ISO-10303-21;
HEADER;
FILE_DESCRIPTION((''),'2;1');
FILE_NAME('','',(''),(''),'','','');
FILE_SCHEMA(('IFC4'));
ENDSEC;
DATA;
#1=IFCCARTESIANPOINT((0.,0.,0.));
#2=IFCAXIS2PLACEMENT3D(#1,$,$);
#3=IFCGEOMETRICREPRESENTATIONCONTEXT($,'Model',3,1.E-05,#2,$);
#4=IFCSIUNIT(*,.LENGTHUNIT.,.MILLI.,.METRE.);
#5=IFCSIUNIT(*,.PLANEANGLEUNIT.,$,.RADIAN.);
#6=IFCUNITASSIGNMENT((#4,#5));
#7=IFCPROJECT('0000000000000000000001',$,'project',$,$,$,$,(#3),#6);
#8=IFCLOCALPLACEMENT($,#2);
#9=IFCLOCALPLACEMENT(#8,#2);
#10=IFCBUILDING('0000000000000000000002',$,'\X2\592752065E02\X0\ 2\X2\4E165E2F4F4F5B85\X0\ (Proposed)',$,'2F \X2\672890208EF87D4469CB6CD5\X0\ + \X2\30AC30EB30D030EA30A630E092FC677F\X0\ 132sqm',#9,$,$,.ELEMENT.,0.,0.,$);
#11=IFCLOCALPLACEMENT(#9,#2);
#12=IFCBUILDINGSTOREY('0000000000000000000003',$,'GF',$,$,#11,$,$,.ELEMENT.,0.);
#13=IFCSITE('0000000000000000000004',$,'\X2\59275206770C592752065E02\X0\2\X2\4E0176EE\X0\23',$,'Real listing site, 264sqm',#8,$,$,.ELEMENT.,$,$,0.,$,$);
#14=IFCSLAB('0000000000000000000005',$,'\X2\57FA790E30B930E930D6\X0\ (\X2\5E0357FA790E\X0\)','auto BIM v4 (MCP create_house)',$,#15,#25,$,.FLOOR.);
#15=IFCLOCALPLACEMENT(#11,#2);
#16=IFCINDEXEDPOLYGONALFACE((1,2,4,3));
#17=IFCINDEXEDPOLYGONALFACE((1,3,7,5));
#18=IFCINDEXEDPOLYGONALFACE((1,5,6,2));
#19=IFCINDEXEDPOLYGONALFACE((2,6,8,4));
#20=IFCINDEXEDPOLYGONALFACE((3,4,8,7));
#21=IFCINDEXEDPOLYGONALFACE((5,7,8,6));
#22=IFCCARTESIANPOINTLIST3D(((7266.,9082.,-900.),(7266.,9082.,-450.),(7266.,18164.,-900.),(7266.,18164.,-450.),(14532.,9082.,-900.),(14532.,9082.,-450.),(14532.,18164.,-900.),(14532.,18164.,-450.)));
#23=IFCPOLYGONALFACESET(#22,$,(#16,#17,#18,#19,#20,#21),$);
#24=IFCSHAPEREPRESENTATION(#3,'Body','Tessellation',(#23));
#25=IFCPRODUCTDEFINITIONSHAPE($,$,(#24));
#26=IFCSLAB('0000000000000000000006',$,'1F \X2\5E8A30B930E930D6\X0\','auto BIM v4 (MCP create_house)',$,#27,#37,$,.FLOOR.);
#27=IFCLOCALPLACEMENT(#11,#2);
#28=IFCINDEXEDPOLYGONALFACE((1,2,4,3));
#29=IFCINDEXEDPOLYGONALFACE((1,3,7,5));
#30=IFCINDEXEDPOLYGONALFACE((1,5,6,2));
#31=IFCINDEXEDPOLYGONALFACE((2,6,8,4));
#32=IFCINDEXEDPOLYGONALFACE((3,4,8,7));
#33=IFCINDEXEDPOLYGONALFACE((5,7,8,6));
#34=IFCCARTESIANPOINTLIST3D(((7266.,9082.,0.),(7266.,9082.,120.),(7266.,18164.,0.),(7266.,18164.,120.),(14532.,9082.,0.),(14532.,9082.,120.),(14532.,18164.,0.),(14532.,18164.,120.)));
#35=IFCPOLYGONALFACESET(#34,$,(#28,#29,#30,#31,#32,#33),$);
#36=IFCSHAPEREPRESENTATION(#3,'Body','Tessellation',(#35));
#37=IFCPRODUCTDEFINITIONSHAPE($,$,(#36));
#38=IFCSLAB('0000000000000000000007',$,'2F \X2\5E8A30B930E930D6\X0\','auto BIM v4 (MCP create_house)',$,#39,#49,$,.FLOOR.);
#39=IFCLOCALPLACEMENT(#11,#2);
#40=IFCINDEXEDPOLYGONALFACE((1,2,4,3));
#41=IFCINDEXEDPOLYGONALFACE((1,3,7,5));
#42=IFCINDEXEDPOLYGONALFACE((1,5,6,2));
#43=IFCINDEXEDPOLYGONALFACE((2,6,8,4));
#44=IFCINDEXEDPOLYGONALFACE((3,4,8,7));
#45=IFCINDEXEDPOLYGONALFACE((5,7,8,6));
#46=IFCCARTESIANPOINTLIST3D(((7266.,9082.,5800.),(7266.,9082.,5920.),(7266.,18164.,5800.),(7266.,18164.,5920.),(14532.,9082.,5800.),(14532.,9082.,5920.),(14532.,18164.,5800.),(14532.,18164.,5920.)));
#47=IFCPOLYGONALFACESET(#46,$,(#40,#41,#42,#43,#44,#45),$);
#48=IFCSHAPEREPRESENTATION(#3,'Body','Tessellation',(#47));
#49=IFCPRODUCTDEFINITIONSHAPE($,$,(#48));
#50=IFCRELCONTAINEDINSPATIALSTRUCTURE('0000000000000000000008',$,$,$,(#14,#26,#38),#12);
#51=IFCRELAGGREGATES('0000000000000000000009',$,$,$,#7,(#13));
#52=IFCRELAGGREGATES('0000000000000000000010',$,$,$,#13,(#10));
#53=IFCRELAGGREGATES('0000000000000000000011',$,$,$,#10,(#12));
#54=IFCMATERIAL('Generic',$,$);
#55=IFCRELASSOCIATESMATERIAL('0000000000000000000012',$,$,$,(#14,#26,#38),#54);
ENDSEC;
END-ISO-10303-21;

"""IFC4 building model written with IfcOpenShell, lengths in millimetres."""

from ifc_helpers import new_model, si_unit, frame, frame_2d, origin, place, context, project, spatial, rectangle, extrude, material, element, save


model = new_model("IFC4")

# Units and contexts
model_context = context("Model", 3, precision=1e-05, world=origin())
ifc_project = project(units=[si_unit("LENGTHUNIT", "METRE", prefix="MILLI"), si_unit("PLANEANGLEUNIT", "RADIAN")], contexts=[model_context])

# Site, building, storey
site_placement = place(None, origin())
site = spatial("IfcSite", under=ifc_project, at=site_placement, Name="大分県大分市2丁目23", ObjectType="Real listing site, 264sqm", CompositionType="ELEMENT", RefElevation=0.0)
building_placement = place(site_placement, origin())
building = spatial("IfcBuilding", under=site, at=building_placement, Name="大分市 2世帯住宅 (Proposed)", ObjectType="2F 木造軸組構法 + ガルバリウム鋼板 132sqm", CompositionType="ELEMENT", ElevationOfRefHeight=0.0, ElevationOfTerrain=0.0)
storey_placement = place(building_placement, origin())
storey = spatial("IfcBuildingStorey", under=building, at=storey_placement, Name="GF", CompositionType="ELEMENT", Elevation=0.0)

# Slabs
ifc_material = material(Name="Generic")
slab_1_placement = place(storey_placement, frame((3633.0, 4541.0, -450.0)))
element("IfcSlab", 1, at=slab_1_placement, inside=storey, material=ifc_material, Name="基礎スラブ (布基礎)", Description="auto BIM v4 (MCP create_house)", PredefinedType="FLOOR", context=model_context, shape_type="SweptSolid", body=[
    extrude(rectangle(XDim=7266.0, YDim=9082.0, at=frame_2d((3633.0, 4541.0))), frame((3633.0, 4541.0, -450.0)), (0.0, 0.0, 1.0), 450.0),
])
slab_2_placement = place(storey_placement, frame((3633.0, 4541.0, 0.0)))
element("IfcSlab", 2, at=slab_2_placement, inside=storey, material=ifc_material, Name="1F 床スラブ", Description="auto BIM v4 (MCP create_house)", PredefinedType="FLOOR", context=model_context, shape_type="SweptSolid", body=[
    extrude(rectangle(XDim=7266.0, YDim=9082.0, at=frame_2d((3633.0, 4541.0))), frame((3633.0, 4541.0, 0.0)), (0.0, 0.0, 1.0), 120.0),
])
slab_3_placement = place(storey_placement, frame((3633.0, 4541.0, 2900.0)))
element("IfcSlab", 3, at=slab_3_placement, inside=storey, material=ifc_material, Name="2F 床スラブ", Description="auto BIM v4 (MCP create_house)", PredefinedType="FLOOR", context=model_context, shape_type="SweptSolid", body=[
    extrude(rectangle(XDim=7266.0, YDim=9082.0, at=frame_2d((3633.0, 4541.0))), frame((3633.0, 4541.0, 2900.0)), (0.0, 0.0, 1.0), 120.0),
])

save(model, "model.ifc")
